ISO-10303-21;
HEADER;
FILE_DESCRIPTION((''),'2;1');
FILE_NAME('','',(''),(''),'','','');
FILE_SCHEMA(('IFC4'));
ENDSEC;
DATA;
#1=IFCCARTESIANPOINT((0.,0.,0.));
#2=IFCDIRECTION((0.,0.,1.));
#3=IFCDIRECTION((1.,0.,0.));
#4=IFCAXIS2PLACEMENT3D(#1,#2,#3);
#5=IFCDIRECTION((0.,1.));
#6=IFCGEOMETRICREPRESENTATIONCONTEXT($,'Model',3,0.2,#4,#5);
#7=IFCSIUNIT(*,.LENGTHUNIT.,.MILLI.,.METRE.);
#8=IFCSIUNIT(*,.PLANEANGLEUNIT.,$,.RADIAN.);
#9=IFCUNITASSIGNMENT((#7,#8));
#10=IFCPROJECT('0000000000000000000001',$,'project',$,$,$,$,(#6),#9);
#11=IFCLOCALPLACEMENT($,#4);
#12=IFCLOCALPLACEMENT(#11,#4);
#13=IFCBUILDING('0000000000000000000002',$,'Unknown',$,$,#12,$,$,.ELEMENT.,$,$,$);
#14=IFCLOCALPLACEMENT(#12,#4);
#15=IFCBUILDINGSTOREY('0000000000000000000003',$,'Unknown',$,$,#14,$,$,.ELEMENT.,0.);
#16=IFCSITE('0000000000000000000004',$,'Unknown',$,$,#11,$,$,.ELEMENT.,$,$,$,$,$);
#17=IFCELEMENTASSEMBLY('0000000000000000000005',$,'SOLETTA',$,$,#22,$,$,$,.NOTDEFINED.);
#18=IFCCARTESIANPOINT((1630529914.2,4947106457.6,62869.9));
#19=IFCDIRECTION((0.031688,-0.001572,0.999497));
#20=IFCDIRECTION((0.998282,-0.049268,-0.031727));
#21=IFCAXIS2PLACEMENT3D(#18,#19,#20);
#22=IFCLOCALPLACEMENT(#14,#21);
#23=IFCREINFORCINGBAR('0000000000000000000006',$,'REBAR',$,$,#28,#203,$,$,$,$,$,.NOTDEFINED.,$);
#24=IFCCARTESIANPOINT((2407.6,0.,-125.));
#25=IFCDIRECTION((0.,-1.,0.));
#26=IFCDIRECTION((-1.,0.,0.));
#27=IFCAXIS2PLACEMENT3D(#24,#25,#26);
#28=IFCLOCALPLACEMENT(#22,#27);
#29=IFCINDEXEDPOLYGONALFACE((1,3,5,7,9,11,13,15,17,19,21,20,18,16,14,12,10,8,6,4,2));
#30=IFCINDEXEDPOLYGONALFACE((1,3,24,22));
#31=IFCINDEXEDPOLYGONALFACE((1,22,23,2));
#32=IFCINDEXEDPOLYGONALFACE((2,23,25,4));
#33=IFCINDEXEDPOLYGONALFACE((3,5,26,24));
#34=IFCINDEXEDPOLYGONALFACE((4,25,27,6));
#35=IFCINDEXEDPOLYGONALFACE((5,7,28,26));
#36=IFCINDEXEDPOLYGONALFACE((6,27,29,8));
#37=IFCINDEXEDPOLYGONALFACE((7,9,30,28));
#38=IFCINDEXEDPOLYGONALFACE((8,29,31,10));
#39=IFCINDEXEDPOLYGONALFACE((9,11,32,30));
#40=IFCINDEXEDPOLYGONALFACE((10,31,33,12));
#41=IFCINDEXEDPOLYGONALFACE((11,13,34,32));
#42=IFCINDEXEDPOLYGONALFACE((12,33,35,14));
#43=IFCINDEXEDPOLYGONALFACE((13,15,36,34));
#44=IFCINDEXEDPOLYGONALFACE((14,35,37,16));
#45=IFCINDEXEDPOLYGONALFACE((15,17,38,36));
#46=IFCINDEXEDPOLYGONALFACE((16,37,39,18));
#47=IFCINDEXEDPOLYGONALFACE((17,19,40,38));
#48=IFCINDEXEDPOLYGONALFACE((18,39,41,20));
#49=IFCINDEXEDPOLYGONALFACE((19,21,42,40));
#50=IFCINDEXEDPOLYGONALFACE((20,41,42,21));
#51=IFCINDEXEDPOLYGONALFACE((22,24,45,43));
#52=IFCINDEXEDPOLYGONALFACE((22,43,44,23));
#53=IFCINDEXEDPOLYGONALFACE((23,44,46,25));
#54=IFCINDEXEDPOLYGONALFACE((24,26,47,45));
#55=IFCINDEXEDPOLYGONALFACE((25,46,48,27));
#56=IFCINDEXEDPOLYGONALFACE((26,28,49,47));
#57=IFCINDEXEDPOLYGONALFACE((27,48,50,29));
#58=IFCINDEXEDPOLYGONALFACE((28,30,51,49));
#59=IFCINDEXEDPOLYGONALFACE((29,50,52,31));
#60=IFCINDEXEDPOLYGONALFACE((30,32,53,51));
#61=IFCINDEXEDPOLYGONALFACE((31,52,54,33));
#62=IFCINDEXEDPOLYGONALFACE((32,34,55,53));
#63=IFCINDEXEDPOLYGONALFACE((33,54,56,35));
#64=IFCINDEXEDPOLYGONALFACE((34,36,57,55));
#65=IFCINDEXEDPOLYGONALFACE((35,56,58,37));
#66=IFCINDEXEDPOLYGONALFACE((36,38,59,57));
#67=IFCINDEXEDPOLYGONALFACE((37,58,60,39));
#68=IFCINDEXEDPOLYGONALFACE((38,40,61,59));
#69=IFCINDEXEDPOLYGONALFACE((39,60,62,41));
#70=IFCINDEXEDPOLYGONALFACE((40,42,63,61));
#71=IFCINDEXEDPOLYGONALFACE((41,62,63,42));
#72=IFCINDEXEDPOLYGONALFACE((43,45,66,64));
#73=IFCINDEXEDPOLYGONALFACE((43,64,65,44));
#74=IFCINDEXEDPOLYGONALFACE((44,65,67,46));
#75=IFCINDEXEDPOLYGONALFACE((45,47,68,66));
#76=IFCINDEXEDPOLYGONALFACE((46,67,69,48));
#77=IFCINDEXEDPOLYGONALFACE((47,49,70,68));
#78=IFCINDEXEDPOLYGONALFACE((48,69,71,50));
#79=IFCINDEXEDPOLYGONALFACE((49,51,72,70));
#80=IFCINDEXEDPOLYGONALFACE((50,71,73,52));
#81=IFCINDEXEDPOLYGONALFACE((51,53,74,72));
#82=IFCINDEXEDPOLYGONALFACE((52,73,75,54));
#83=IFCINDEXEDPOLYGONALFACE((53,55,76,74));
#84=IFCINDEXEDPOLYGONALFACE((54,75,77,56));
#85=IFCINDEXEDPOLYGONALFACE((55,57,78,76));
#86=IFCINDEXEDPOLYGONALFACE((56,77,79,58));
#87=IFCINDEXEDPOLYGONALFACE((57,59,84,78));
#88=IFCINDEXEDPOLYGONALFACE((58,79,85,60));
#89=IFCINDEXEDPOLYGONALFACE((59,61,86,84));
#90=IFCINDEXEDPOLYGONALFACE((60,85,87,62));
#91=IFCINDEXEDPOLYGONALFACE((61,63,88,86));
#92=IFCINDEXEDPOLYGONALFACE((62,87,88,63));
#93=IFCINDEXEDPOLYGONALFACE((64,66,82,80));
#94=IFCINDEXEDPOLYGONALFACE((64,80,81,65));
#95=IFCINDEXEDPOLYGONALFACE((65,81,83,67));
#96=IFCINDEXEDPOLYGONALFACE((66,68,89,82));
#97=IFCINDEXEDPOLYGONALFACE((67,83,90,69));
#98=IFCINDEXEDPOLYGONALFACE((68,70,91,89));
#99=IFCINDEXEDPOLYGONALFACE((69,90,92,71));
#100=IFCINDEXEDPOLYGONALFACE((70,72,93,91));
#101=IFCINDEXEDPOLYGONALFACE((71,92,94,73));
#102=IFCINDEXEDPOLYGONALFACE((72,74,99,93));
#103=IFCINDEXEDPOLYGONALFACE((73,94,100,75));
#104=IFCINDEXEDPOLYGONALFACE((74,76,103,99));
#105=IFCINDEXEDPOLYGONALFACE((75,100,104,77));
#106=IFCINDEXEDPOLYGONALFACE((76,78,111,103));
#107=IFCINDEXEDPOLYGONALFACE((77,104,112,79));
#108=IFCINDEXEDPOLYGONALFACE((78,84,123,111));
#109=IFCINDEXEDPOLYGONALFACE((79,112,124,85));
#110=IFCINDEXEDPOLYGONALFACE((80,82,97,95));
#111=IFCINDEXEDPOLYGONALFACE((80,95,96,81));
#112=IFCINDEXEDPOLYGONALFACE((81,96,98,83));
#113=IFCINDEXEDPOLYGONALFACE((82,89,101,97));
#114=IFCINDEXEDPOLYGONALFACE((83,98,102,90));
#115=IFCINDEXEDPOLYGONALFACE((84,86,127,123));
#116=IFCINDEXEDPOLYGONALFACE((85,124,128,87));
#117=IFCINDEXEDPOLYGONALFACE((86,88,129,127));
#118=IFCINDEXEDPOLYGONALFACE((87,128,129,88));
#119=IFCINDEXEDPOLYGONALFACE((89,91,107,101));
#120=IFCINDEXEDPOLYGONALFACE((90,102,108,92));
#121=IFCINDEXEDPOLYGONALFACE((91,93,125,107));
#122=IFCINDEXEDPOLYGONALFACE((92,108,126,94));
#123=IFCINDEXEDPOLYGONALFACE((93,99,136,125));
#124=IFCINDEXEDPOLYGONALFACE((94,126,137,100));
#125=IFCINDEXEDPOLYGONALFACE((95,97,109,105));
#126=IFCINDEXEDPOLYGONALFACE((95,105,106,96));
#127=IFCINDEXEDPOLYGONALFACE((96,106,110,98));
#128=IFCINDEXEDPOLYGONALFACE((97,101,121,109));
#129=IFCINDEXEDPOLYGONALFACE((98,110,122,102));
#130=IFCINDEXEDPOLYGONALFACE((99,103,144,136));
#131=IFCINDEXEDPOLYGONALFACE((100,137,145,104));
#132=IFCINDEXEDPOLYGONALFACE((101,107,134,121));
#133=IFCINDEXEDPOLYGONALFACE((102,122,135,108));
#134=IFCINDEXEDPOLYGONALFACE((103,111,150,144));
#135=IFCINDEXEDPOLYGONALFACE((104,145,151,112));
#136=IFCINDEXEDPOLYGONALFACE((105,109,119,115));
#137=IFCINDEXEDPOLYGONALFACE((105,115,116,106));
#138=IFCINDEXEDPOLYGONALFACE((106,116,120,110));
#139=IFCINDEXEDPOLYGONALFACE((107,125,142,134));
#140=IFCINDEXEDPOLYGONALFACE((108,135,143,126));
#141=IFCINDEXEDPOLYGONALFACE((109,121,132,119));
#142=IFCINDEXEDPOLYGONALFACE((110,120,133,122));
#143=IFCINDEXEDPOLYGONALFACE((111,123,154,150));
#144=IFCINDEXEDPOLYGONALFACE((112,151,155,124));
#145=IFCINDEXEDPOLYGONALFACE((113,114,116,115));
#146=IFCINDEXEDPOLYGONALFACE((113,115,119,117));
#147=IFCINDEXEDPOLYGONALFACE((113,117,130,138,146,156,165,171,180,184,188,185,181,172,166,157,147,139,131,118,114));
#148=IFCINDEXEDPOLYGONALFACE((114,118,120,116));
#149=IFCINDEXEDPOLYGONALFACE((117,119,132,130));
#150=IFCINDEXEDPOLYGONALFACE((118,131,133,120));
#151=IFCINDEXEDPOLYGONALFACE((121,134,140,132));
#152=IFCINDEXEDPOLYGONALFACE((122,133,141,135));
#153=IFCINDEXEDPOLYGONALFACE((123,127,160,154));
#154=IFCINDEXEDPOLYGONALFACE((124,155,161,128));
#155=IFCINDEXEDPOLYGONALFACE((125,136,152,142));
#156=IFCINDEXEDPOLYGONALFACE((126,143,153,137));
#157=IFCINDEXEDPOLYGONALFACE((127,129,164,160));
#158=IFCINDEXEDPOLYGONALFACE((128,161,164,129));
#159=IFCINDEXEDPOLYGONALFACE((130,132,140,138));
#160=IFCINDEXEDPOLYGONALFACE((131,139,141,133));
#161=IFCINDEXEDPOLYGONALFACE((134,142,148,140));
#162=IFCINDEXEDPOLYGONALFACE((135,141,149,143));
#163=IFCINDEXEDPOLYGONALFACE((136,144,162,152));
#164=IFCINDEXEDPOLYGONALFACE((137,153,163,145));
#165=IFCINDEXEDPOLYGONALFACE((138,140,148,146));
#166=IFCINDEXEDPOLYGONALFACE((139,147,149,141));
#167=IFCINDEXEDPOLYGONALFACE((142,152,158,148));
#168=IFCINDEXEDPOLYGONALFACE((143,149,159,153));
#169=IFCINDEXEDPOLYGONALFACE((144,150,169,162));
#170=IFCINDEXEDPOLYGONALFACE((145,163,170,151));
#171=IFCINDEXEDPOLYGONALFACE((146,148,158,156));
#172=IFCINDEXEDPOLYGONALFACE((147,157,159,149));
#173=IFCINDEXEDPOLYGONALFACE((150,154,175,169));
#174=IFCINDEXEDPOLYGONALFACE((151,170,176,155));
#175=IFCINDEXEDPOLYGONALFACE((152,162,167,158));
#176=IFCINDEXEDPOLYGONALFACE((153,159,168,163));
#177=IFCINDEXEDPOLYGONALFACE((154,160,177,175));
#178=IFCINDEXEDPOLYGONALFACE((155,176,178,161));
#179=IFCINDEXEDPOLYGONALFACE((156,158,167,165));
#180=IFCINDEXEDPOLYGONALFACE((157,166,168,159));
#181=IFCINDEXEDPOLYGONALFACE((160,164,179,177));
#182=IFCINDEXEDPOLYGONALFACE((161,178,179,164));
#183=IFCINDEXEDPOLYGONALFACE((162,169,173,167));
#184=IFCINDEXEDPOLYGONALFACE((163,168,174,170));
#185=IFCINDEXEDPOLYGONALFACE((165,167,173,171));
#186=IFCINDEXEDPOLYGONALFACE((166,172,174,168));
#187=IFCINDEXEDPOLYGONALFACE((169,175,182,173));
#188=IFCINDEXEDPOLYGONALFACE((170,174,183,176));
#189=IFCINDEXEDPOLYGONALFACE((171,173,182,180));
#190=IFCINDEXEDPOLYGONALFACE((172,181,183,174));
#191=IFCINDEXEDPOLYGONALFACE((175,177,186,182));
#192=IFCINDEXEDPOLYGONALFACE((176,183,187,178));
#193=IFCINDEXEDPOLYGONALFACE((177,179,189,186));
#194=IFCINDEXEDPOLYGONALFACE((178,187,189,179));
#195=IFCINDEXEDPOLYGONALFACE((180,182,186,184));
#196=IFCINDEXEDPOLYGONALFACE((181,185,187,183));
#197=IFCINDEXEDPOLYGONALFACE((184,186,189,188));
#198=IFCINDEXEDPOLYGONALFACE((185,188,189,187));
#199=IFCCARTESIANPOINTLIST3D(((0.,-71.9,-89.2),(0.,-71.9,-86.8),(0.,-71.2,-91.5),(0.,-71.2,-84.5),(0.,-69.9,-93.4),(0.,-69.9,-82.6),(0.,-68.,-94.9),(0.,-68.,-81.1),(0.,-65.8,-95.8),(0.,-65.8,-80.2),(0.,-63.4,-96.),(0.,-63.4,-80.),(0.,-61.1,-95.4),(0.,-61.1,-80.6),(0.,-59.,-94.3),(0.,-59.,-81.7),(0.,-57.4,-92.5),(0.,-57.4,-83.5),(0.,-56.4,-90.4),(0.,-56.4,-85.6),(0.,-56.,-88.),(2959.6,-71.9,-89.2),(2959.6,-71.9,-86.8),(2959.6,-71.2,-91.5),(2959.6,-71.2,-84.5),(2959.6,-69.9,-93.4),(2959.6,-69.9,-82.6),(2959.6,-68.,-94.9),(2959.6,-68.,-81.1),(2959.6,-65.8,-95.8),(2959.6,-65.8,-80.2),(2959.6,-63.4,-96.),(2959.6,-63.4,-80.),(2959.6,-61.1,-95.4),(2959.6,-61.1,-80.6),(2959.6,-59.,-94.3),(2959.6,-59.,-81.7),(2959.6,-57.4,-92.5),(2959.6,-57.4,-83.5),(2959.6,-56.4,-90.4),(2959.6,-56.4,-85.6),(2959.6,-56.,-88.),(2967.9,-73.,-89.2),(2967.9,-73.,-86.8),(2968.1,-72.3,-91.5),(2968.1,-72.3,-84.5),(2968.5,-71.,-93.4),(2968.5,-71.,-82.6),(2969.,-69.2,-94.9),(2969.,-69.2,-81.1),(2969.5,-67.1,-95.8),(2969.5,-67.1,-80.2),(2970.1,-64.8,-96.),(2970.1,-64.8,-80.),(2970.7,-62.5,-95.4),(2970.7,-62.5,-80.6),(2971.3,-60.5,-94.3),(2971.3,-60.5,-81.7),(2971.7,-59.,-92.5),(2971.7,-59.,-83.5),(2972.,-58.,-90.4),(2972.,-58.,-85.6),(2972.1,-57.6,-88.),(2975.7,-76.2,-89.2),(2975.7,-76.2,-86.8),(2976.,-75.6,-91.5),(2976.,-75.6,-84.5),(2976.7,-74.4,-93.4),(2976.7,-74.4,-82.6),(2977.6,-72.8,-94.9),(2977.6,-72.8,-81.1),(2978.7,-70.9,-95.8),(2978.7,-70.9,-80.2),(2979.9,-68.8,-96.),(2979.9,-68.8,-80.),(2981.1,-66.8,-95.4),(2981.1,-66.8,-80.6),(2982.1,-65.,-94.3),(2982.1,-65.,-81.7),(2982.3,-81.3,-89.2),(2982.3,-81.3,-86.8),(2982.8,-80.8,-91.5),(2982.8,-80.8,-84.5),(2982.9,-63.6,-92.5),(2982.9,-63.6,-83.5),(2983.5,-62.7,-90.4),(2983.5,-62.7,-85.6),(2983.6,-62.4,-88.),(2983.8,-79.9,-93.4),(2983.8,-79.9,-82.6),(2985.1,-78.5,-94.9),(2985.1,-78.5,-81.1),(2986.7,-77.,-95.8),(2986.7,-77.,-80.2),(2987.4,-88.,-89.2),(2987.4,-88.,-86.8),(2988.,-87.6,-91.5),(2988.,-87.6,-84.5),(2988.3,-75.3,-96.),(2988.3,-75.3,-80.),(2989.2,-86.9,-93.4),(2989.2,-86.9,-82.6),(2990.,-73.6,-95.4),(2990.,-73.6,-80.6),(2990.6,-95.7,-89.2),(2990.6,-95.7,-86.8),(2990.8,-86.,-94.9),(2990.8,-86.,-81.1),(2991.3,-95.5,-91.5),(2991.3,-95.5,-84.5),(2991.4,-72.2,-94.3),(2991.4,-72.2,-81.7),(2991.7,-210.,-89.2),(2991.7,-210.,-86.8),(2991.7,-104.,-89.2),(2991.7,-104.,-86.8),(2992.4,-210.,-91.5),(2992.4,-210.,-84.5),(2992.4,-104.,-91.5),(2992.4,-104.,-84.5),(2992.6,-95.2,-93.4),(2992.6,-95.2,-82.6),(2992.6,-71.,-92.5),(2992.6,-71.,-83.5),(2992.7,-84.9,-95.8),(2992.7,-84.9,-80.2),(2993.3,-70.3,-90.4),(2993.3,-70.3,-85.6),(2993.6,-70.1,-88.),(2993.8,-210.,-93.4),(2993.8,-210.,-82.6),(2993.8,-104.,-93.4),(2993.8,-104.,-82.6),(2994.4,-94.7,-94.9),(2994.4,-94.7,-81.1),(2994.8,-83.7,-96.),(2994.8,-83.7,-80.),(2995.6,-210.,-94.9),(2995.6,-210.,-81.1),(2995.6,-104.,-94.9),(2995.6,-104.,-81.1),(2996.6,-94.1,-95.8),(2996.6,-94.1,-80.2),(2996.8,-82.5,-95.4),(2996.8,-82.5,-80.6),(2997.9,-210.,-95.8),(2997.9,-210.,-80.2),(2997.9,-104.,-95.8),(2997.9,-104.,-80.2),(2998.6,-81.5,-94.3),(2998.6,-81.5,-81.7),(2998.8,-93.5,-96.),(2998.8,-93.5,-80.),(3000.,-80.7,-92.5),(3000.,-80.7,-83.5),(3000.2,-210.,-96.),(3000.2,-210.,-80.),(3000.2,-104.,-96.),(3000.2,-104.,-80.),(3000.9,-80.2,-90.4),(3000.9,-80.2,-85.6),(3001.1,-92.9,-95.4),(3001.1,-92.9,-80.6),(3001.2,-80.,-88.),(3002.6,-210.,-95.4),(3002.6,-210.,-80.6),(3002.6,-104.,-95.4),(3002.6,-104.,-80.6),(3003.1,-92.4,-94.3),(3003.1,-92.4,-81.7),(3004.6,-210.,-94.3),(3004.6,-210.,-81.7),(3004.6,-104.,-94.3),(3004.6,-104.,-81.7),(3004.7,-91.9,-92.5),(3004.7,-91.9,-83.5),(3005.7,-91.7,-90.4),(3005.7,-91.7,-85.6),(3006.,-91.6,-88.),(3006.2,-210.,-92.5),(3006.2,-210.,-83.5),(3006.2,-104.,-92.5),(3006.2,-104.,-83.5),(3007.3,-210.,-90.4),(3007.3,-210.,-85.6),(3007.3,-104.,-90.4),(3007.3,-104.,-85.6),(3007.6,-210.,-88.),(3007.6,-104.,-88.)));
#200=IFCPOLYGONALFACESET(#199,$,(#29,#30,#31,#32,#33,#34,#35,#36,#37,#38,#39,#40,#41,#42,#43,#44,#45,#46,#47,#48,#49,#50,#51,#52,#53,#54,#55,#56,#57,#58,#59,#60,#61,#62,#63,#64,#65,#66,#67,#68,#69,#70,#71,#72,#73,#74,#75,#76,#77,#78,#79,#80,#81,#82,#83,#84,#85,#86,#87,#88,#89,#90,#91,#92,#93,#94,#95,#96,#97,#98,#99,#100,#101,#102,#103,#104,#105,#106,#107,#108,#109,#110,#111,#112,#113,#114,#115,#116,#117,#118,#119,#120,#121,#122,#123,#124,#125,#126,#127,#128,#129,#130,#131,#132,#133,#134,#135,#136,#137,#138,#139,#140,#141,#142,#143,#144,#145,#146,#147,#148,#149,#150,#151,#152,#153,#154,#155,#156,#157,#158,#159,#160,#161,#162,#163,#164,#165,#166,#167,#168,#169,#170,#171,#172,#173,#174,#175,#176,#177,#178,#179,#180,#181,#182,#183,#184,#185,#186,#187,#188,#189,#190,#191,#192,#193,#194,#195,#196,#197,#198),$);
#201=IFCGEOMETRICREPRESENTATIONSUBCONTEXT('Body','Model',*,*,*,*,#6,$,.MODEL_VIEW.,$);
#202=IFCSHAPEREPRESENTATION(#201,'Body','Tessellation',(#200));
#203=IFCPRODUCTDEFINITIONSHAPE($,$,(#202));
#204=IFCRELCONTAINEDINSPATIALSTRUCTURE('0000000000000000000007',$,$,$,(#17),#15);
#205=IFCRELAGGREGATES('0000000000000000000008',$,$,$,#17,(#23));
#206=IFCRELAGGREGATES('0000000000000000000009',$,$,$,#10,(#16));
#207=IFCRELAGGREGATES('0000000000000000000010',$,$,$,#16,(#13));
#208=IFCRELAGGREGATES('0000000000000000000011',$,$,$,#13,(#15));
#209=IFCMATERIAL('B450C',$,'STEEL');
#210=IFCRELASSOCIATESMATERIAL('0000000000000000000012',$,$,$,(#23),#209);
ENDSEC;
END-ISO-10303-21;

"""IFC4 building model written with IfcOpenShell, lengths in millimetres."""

from ifc_helpers import new_model, entity, si_unit, direction, frame, origin_with_axes, place, context, subcontext, project, spatial, material, element, aggregate, save


model = new_model("IFC4")

# Units and contexts
model_context = context("Model", 3, precision=0.2, world=origin_with_axes(), true_north=direction((0.0, 1.0)))
body_context = subcontext(model_context, "Body", "Model", "MODEL_VIEW")
ifc_project = project(units=[si_unit("LENGTHUNIT", "METRE", prefix="MILLI"), si_unit("PLANEANGLEUNIT", "RADIAN")], contexts=[model_context])

# Site, building, storey
site_placement = place(None, origin_with_axes())
site = spatial("IfcSite", under=ifc_project, at=site_placement, Name="Unknown", CompositionType="ELEMENT")
building_placement = place(site_placement, origin_with_axes())
building = spatial("IfcBuilding", under=site, at=building_placement, Name="Unknown", CompositionType="ELEMENT")
storey_placement = place(building_placement, origin_with_axes())
storey = spatial("IfcBuildingStorey", under=building, at=storey_placement, Name="Unknown", CompositionType="ELEMENT", Elevation=0.0)

# Element assembly
ifc_material = material(Name="B450C", Category="STEEL")
assembly_1_placement = place(storey_placement, frame((1630529914.2, 4947106457.6, 62869.9), z_axis=(0.031688, -0.001572, 0.999497), x_axis=(0.998282, -0.049268, -0.031727)))
assembly_1 = element("IfcElementAssembly", 1, at=assembly_1_placement, inside=storey, Name="SOLETTA", PredefinedType="NOTDEFINED")

# Reinforcing bar
reinforcing_bar_1_placement = place(assembly_1_placement, frame((2407.6, 0.0, -125.0), z_axis=(0.0, -1.0, 0.0), x_axis=(-1.0, 0.0, 0.0)))
reinforcing_bar_1 = element("IfcReinforcingBar", 2, at=reinforcing_bar_1_placement, material=ifc_material, Name="REBAR", PredefinedType="NOTDEFINED", context=body_context, shape_type="AdvancedSweptSolid", body=[
    entity("IfcSweptDiskSolid", entity("IfcIndexedPolyCurve", entity("IfcCartesianPointList3D", [[0.0, -64.0, -88.0], [2959.6, -64.0, -88.0], [2987.9, -75.7, -88.0], [2999.6, -104.0, -88.0], [2999.6, -210.0, -88.0]]), [entity("IfcLineIndex", [1, 2]), entity("IfcArcIndex", [2, 3, 4]), entity("IfcLineIndex", [4, 5])]), 8.0),
])
aggregate(assembly_1, [reinforcing_bar_1])

save(model, "model.ifc")
